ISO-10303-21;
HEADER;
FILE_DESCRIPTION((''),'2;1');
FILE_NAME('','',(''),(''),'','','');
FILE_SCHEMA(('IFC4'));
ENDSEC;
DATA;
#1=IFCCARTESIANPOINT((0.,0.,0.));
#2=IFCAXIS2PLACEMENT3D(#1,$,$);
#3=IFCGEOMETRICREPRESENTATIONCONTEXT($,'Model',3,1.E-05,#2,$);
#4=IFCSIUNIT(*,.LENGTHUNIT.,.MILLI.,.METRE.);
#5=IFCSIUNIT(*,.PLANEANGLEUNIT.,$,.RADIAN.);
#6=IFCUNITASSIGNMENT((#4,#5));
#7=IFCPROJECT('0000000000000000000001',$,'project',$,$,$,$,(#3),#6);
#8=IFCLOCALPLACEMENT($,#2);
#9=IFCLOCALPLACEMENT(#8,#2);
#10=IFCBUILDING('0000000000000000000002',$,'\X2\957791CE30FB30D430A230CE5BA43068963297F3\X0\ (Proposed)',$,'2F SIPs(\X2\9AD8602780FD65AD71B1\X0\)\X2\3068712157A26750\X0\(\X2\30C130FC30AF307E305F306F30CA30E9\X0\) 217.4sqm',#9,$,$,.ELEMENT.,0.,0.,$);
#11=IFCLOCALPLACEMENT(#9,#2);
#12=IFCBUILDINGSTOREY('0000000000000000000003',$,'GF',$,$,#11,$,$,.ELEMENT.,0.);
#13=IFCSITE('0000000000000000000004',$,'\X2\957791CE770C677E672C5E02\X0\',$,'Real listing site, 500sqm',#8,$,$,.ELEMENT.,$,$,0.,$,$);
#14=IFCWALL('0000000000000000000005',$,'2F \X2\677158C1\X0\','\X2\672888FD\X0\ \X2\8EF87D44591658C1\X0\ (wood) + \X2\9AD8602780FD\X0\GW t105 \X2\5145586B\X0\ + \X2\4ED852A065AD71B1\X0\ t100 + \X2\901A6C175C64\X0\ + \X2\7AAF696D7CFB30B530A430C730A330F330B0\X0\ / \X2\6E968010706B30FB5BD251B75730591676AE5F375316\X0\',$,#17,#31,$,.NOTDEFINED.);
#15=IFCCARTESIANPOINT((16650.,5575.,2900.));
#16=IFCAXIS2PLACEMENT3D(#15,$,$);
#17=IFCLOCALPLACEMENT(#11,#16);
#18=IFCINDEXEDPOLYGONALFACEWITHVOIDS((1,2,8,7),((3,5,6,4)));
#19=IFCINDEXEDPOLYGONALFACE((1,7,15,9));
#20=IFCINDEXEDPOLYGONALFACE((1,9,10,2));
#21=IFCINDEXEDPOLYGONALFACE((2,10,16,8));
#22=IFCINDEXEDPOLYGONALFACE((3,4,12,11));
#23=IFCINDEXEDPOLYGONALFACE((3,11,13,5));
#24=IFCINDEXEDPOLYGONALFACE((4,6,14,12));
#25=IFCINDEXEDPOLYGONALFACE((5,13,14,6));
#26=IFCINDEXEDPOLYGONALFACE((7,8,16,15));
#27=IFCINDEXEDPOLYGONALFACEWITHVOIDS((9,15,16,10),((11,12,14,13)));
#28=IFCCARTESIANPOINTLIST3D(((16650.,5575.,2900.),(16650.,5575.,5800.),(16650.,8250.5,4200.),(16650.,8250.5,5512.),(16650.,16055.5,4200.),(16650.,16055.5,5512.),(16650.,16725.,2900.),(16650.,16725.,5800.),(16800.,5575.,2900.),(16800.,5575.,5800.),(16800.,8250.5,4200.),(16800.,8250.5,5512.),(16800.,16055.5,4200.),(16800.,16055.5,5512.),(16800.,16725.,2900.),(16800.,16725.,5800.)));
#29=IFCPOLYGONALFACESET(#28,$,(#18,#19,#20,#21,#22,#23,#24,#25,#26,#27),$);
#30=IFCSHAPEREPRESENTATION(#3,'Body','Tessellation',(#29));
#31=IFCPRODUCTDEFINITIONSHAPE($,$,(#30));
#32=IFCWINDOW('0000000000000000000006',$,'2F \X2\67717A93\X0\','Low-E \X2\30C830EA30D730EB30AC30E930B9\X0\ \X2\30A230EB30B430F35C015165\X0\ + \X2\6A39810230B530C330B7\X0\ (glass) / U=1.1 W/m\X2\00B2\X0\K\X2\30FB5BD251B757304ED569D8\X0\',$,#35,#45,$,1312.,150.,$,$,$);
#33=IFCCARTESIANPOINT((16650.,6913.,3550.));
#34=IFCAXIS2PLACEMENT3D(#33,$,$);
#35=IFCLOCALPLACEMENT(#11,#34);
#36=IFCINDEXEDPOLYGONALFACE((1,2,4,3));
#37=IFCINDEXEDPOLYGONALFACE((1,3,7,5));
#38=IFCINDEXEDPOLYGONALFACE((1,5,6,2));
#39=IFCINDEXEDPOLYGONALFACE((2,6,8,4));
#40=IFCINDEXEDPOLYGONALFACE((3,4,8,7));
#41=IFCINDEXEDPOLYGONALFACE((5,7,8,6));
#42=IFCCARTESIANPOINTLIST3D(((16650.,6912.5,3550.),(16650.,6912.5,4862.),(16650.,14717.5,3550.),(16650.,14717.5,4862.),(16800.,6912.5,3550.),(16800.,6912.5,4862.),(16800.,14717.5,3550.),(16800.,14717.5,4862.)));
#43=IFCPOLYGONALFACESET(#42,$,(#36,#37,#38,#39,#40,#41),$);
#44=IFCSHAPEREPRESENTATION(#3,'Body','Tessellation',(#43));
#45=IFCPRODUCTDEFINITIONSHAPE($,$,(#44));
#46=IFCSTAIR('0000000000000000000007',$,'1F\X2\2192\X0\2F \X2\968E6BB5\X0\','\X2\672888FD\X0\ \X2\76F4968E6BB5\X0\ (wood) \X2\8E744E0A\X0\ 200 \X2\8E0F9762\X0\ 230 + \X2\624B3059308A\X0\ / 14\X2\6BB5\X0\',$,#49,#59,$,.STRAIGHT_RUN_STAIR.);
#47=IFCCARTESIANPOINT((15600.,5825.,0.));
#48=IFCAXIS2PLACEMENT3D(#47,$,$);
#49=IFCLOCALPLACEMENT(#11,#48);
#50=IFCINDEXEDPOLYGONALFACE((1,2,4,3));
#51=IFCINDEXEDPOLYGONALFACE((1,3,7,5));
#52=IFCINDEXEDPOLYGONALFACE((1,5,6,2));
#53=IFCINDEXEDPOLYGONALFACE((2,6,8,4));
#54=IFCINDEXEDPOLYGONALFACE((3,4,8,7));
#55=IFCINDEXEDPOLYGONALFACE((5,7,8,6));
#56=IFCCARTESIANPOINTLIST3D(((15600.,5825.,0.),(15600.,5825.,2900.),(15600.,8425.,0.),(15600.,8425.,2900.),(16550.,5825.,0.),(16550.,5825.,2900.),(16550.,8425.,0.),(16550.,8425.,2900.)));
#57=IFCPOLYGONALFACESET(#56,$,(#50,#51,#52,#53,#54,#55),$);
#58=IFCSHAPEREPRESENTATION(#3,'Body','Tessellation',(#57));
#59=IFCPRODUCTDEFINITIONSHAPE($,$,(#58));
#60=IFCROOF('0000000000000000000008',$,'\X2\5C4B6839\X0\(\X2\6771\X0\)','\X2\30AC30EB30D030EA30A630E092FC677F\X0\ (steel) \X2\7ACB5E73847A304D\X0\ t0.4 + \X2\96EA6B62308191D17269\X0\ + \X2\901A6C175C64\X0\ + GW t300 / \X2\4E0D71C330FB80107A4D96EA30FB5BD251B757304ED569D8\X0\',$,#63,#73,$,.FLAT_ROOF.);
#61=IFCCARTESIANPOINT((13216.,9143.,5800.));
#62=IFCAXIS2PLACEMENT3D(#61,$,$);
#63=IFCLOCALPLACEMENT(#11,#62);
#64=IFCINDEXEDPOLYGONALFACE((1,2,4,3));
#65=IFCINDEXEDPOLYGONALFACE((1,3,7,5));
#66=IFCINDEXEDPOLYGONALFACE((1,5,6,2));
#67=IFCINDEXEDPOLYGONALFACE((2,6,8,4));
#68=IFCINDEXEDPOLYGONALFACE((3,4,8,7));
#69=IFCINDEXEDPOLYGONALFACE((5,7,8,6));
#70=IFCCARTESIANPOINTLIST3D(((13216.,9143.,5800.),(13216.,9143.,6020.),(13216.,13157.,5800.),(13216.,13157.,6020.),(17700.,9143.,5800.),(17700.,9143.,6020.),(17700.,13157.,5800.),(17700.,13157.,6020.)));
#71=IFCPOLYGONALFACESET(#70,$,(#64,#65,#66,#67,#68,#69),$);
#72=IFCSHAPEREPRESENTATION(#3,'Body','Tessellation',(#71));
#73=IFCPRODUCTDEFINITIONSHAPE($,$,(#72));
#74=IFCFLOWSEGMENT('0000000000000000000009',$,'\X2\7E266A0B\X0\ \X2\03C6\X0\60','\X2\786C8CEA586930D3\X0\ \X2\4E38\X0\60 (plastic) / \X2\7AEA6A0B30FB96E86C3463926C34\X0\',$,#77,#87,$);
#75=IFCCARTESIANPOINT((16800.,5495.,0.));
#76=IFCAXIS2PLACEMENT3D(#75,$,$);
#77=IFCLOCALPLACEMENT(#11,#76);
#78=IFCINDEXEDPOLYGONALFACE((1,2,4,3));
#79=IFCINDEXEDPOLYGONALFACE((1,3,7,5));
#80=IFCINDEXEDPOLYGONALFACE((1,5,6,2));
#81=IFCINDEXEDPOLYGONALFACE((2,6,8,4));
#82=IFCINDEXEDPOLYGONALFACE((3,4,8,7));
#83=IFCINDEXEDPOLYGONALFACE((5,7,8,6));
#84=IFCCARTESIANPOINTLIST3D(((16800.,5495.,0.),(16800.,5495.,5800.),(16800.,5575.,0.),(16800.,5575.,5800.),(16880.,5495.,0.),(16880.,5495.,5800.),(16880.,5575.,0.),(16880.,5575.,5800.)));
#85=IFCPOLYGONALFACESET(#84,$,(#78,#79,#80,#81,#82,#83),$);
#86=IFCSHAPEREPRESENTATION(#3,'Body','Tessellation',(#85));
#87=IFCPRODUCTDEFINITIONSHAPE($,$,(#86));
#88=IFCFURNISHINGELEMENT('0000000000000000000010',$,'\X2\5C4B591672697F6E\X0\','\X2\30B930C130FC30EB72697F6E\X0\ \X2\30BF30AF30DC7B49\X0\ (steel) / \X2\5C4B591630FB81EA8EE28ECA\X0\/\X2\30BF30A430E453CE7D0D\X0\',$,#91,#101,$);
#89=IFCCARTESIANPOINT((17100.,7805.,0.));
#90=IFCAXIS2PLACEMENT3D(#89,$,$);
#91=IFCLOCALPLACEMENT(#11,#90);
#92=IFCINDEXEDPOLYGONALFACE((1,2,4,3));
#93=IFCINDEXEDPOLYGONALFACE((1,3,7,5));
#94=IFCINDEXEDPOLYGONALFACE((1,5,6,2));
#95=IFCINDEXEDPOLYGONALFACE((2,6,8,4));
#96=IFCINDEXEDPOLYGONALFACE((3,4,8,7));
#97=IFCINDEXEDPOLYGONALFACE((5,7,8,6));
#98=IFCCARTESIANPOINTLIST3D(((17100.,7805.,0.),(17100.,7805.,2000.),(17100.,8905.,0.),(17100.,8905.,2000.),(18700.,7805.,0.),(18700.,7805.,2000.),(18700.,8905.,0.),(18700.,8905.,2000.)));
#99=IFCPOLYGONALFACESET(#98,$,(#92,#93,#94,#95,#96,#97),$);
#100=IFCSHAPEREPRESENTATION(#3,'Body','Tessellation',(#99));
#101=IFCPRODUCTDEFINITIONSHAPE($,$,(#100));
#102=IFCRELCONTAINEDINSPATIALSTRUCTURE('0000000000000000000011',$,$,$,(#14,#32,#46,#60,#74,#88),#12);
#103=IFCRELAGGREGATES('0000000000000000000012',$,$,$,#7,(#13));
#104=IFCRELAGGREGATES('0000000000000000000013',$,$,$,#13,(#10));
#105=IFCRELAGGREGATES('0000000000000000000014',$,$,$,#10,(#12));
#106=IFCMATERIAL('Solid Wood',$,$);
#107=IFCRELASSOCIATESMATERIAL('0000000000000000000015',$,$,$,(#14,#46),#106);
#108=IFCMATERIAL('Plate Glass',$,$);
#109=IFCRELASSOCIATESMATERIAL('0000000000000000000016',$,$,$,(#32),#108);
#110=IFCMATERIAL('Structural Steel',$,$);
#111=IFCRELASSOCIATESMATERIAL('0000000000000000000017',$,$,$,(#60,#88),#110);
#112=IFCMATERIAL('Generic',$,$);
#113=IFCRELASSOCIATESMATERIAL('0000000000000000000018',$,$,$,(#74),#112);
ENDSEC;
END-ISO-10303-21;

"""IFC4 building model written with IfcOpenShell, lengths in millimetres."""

from ifc_helpers import new_model, si_unit, frame, frame_2d, origin, place, context, project, spatial, rectangle, extrude, material, element, fill, save


model = new_model("IFC4")

# Units and contexts
model_context = context("Model", 3, precision=1e-05, world=origin())
ifc_project = project(units=[si_unit("LENGTHUNIT", "METRE", prefix="MILLI"), si_unit("PLANEANGLEUNIT", "RADIAN")], contexts=[model_context])

# Site, building, storey
site_placement = place(None, origin())
site = spatial("IfcSite", under=ifc_project, at=site_placement, Name="長野県松本市", ObjectType="Real listing site, 500sqm", CompositionType="ELEMENT", RefElevation=0.0)
building_placement = place(site_placement, origin())
building = spatial("IfcBuilding", under=site, at=building_placement, Name="長野・ピアノ室と防音 (Proposed)", ObjectType="2F SIPs(高性能断熱)と無垢材(チークまたはナラ) 217.4sqm", CompositionType="ELEMENT", ElevationOfRefHeight=0.0, ElevationOfTerrain=0.0)
storey_placement = place(building_placement, origin())
storey = spatial("IfcBuildingStorey", under=building, at=storey_placement, Name="GF", CompositionType="ELEMENT", Elevation=0.0)

# Shared definitions
ifc_material_1 = material(Name="Solid Wood")

# Wall, opening, window
ifc_material_2 = material(Name="Plate Glass")
wall_1_placement = place(storey_placement, frame((16650.0, 5575.0, 2900.0)))
wall_1 = element("IfcWall", 1, at=wall_1_placement, inside=storey, material=ifc_material_1, Name="2F 東壁", Description="木製 軸組外壁 (wood) + 高性能GW t105 充填 + 付加断熱 t100 + 通気層 + 窯業系サイディング / 準耐火・寒冷地外皮強化", PredefinedType="NOTDEFINED", context=model_context, shape_type="SweptSolid", body=[
    extrude(rectangle(XDim=150.0, YDim=11150.0, at=frame_2d((75.0, 5575.0))), frame((16650.0, 5575.0, 2900.0)), (0.0, 0.0, 1.0), 2900.0),
])
opening_1_placement = place(storey_placement, frame((16650.0, 6913.0, 3550.0)))
opening_1 = element("IfcOpeningElement", 2, at=opening_1_placement, cuts=wall_1, PredefinedType="NOTDEFINED", context=model_context, shape_type="SweptSolid", body=[
    extrude(rectangle(XDim=150.0, YDim=7805.0, at=frame_2d((75.0, 3902.0))), frame((16650.0, 6913.0, 3550.0)), (0.0, 0.0, 1.0), 1312.0),
])
window_1_placement = place(storey_placement, frame((16650.0, 6913.0, 3550.0)))
window_1 = element("IfcWindow", 3, at=window_1_placement, inside=storey, material=ifc_material_2, Name="2F 東窓", Description="Low-E トリプルガラス アルゴン封入 + 樹脂サッシ (glass) / U=1.1 W/m²K・寒冷地仕様", OverallHeight=1312.0, OverallWidth=150.0, context=model_context, shape_type="SweptSolid", body=[
    extrude(rectangle(XDim=150.0, YDim=7805.0, at=frame_2d((75.0, 3902.0))), frame((16650.0, 6913.0, 3550.0)), (0.0, 0.0, 1.0), 1312.0),
])
fill(opening_1, window_1)

# Stair
stair_placement = place(storey_placement, frame((15600.0, 5825.0, 0.0)))
element("IfcStair", 4, at=stair_placement, inside=storey, material=ifc_material_1, Name="1F→2F 階段", Description="木製 直階段 (wood) 蹴上 200 踏面 230 + 手すり / 14段", PredefinedType="STRAIGHT_RUN_STAIR", context=model_context, shape_type="SweptSolid", body=[
    extrude(rectangle(XDim=950.0, YDim=2600.0, at=frame_2d((475.0, 1300.0))), frame((15600.0, 5825.0, 0.0)), (0.0, 0.0, 1.0), 2900.0),
])

# Roof
ifc_material_3 = material(Name="Structural Steel")
roof_placement = place(storey_placement, frame((13216.0, 9143.0, 5800.0)))
element("IfcRoof", 5, at=roof_placement, inside=storey, material=ifc_material_3, Name="屋根(東)", Description="ガルバリウム鋼板 (steel) 立平葺き t0.4 + 雪止め金物 + 通気層 + GW t300 / 不燃・耐積雪・寒冷地仕様", PredefinedType="FLAT_ROOF", context=model_context, shape_type="SweptSolid", body=[
    extrude(rectangle(XDim=4484.0, YDim=4014.0, at=frame_2d((2242.0, 2007.0))), frame((13216.0, 9143.0, 5800.0)), (0.0, 0.0, 1.0), 220.0),
])

# Flow segment
ifc_material_4 = material(Name="Generic")
flow_segment_placement = place(storey_placement, frame((16800.0, 5495.0, 0.0)))
element("IfcFlowSegment", 6, at=flow_segment_placement, inside=storey, material=ifc_material_4, Name="縦樋 φ60", Description="硬質塩ビ 丸60 (plastic) / 竪樋・雨水排水", context=model_context, shape_type="SweptSolid", body=[
    extrude(rectangle(XDim=80.0, YDim=80.0, at=frame_2d((40.0, 40.0))), frame((16800.0, 5495.0, 0.0)), (0.0, 0.0, 1.0), 5800.0),
])

# Furnishing element
furnishing_placement = place(storey_placement, frame((17100.0, 7805.0, 0.0)))
element("IfcFurnishingElement", 7, at=furnishing_placement, inside=storey, material=ifc_material_3, Name="屋外物置", Description="スチール物置 タクボ等 (steel) / 屋外・自転車/タイヤ収納", context=model_context, shape_type="SweptSolid", body=[
    extrude(rectangle(XDim=1600.0, YDim=1100.0, at=frame_2d((800.0, 550.0))), frame((17100.0, 7805.0, 0.0)), (0.0, 0.0, 1.0), 2000.0),
])

save(model, "model.ifc")
